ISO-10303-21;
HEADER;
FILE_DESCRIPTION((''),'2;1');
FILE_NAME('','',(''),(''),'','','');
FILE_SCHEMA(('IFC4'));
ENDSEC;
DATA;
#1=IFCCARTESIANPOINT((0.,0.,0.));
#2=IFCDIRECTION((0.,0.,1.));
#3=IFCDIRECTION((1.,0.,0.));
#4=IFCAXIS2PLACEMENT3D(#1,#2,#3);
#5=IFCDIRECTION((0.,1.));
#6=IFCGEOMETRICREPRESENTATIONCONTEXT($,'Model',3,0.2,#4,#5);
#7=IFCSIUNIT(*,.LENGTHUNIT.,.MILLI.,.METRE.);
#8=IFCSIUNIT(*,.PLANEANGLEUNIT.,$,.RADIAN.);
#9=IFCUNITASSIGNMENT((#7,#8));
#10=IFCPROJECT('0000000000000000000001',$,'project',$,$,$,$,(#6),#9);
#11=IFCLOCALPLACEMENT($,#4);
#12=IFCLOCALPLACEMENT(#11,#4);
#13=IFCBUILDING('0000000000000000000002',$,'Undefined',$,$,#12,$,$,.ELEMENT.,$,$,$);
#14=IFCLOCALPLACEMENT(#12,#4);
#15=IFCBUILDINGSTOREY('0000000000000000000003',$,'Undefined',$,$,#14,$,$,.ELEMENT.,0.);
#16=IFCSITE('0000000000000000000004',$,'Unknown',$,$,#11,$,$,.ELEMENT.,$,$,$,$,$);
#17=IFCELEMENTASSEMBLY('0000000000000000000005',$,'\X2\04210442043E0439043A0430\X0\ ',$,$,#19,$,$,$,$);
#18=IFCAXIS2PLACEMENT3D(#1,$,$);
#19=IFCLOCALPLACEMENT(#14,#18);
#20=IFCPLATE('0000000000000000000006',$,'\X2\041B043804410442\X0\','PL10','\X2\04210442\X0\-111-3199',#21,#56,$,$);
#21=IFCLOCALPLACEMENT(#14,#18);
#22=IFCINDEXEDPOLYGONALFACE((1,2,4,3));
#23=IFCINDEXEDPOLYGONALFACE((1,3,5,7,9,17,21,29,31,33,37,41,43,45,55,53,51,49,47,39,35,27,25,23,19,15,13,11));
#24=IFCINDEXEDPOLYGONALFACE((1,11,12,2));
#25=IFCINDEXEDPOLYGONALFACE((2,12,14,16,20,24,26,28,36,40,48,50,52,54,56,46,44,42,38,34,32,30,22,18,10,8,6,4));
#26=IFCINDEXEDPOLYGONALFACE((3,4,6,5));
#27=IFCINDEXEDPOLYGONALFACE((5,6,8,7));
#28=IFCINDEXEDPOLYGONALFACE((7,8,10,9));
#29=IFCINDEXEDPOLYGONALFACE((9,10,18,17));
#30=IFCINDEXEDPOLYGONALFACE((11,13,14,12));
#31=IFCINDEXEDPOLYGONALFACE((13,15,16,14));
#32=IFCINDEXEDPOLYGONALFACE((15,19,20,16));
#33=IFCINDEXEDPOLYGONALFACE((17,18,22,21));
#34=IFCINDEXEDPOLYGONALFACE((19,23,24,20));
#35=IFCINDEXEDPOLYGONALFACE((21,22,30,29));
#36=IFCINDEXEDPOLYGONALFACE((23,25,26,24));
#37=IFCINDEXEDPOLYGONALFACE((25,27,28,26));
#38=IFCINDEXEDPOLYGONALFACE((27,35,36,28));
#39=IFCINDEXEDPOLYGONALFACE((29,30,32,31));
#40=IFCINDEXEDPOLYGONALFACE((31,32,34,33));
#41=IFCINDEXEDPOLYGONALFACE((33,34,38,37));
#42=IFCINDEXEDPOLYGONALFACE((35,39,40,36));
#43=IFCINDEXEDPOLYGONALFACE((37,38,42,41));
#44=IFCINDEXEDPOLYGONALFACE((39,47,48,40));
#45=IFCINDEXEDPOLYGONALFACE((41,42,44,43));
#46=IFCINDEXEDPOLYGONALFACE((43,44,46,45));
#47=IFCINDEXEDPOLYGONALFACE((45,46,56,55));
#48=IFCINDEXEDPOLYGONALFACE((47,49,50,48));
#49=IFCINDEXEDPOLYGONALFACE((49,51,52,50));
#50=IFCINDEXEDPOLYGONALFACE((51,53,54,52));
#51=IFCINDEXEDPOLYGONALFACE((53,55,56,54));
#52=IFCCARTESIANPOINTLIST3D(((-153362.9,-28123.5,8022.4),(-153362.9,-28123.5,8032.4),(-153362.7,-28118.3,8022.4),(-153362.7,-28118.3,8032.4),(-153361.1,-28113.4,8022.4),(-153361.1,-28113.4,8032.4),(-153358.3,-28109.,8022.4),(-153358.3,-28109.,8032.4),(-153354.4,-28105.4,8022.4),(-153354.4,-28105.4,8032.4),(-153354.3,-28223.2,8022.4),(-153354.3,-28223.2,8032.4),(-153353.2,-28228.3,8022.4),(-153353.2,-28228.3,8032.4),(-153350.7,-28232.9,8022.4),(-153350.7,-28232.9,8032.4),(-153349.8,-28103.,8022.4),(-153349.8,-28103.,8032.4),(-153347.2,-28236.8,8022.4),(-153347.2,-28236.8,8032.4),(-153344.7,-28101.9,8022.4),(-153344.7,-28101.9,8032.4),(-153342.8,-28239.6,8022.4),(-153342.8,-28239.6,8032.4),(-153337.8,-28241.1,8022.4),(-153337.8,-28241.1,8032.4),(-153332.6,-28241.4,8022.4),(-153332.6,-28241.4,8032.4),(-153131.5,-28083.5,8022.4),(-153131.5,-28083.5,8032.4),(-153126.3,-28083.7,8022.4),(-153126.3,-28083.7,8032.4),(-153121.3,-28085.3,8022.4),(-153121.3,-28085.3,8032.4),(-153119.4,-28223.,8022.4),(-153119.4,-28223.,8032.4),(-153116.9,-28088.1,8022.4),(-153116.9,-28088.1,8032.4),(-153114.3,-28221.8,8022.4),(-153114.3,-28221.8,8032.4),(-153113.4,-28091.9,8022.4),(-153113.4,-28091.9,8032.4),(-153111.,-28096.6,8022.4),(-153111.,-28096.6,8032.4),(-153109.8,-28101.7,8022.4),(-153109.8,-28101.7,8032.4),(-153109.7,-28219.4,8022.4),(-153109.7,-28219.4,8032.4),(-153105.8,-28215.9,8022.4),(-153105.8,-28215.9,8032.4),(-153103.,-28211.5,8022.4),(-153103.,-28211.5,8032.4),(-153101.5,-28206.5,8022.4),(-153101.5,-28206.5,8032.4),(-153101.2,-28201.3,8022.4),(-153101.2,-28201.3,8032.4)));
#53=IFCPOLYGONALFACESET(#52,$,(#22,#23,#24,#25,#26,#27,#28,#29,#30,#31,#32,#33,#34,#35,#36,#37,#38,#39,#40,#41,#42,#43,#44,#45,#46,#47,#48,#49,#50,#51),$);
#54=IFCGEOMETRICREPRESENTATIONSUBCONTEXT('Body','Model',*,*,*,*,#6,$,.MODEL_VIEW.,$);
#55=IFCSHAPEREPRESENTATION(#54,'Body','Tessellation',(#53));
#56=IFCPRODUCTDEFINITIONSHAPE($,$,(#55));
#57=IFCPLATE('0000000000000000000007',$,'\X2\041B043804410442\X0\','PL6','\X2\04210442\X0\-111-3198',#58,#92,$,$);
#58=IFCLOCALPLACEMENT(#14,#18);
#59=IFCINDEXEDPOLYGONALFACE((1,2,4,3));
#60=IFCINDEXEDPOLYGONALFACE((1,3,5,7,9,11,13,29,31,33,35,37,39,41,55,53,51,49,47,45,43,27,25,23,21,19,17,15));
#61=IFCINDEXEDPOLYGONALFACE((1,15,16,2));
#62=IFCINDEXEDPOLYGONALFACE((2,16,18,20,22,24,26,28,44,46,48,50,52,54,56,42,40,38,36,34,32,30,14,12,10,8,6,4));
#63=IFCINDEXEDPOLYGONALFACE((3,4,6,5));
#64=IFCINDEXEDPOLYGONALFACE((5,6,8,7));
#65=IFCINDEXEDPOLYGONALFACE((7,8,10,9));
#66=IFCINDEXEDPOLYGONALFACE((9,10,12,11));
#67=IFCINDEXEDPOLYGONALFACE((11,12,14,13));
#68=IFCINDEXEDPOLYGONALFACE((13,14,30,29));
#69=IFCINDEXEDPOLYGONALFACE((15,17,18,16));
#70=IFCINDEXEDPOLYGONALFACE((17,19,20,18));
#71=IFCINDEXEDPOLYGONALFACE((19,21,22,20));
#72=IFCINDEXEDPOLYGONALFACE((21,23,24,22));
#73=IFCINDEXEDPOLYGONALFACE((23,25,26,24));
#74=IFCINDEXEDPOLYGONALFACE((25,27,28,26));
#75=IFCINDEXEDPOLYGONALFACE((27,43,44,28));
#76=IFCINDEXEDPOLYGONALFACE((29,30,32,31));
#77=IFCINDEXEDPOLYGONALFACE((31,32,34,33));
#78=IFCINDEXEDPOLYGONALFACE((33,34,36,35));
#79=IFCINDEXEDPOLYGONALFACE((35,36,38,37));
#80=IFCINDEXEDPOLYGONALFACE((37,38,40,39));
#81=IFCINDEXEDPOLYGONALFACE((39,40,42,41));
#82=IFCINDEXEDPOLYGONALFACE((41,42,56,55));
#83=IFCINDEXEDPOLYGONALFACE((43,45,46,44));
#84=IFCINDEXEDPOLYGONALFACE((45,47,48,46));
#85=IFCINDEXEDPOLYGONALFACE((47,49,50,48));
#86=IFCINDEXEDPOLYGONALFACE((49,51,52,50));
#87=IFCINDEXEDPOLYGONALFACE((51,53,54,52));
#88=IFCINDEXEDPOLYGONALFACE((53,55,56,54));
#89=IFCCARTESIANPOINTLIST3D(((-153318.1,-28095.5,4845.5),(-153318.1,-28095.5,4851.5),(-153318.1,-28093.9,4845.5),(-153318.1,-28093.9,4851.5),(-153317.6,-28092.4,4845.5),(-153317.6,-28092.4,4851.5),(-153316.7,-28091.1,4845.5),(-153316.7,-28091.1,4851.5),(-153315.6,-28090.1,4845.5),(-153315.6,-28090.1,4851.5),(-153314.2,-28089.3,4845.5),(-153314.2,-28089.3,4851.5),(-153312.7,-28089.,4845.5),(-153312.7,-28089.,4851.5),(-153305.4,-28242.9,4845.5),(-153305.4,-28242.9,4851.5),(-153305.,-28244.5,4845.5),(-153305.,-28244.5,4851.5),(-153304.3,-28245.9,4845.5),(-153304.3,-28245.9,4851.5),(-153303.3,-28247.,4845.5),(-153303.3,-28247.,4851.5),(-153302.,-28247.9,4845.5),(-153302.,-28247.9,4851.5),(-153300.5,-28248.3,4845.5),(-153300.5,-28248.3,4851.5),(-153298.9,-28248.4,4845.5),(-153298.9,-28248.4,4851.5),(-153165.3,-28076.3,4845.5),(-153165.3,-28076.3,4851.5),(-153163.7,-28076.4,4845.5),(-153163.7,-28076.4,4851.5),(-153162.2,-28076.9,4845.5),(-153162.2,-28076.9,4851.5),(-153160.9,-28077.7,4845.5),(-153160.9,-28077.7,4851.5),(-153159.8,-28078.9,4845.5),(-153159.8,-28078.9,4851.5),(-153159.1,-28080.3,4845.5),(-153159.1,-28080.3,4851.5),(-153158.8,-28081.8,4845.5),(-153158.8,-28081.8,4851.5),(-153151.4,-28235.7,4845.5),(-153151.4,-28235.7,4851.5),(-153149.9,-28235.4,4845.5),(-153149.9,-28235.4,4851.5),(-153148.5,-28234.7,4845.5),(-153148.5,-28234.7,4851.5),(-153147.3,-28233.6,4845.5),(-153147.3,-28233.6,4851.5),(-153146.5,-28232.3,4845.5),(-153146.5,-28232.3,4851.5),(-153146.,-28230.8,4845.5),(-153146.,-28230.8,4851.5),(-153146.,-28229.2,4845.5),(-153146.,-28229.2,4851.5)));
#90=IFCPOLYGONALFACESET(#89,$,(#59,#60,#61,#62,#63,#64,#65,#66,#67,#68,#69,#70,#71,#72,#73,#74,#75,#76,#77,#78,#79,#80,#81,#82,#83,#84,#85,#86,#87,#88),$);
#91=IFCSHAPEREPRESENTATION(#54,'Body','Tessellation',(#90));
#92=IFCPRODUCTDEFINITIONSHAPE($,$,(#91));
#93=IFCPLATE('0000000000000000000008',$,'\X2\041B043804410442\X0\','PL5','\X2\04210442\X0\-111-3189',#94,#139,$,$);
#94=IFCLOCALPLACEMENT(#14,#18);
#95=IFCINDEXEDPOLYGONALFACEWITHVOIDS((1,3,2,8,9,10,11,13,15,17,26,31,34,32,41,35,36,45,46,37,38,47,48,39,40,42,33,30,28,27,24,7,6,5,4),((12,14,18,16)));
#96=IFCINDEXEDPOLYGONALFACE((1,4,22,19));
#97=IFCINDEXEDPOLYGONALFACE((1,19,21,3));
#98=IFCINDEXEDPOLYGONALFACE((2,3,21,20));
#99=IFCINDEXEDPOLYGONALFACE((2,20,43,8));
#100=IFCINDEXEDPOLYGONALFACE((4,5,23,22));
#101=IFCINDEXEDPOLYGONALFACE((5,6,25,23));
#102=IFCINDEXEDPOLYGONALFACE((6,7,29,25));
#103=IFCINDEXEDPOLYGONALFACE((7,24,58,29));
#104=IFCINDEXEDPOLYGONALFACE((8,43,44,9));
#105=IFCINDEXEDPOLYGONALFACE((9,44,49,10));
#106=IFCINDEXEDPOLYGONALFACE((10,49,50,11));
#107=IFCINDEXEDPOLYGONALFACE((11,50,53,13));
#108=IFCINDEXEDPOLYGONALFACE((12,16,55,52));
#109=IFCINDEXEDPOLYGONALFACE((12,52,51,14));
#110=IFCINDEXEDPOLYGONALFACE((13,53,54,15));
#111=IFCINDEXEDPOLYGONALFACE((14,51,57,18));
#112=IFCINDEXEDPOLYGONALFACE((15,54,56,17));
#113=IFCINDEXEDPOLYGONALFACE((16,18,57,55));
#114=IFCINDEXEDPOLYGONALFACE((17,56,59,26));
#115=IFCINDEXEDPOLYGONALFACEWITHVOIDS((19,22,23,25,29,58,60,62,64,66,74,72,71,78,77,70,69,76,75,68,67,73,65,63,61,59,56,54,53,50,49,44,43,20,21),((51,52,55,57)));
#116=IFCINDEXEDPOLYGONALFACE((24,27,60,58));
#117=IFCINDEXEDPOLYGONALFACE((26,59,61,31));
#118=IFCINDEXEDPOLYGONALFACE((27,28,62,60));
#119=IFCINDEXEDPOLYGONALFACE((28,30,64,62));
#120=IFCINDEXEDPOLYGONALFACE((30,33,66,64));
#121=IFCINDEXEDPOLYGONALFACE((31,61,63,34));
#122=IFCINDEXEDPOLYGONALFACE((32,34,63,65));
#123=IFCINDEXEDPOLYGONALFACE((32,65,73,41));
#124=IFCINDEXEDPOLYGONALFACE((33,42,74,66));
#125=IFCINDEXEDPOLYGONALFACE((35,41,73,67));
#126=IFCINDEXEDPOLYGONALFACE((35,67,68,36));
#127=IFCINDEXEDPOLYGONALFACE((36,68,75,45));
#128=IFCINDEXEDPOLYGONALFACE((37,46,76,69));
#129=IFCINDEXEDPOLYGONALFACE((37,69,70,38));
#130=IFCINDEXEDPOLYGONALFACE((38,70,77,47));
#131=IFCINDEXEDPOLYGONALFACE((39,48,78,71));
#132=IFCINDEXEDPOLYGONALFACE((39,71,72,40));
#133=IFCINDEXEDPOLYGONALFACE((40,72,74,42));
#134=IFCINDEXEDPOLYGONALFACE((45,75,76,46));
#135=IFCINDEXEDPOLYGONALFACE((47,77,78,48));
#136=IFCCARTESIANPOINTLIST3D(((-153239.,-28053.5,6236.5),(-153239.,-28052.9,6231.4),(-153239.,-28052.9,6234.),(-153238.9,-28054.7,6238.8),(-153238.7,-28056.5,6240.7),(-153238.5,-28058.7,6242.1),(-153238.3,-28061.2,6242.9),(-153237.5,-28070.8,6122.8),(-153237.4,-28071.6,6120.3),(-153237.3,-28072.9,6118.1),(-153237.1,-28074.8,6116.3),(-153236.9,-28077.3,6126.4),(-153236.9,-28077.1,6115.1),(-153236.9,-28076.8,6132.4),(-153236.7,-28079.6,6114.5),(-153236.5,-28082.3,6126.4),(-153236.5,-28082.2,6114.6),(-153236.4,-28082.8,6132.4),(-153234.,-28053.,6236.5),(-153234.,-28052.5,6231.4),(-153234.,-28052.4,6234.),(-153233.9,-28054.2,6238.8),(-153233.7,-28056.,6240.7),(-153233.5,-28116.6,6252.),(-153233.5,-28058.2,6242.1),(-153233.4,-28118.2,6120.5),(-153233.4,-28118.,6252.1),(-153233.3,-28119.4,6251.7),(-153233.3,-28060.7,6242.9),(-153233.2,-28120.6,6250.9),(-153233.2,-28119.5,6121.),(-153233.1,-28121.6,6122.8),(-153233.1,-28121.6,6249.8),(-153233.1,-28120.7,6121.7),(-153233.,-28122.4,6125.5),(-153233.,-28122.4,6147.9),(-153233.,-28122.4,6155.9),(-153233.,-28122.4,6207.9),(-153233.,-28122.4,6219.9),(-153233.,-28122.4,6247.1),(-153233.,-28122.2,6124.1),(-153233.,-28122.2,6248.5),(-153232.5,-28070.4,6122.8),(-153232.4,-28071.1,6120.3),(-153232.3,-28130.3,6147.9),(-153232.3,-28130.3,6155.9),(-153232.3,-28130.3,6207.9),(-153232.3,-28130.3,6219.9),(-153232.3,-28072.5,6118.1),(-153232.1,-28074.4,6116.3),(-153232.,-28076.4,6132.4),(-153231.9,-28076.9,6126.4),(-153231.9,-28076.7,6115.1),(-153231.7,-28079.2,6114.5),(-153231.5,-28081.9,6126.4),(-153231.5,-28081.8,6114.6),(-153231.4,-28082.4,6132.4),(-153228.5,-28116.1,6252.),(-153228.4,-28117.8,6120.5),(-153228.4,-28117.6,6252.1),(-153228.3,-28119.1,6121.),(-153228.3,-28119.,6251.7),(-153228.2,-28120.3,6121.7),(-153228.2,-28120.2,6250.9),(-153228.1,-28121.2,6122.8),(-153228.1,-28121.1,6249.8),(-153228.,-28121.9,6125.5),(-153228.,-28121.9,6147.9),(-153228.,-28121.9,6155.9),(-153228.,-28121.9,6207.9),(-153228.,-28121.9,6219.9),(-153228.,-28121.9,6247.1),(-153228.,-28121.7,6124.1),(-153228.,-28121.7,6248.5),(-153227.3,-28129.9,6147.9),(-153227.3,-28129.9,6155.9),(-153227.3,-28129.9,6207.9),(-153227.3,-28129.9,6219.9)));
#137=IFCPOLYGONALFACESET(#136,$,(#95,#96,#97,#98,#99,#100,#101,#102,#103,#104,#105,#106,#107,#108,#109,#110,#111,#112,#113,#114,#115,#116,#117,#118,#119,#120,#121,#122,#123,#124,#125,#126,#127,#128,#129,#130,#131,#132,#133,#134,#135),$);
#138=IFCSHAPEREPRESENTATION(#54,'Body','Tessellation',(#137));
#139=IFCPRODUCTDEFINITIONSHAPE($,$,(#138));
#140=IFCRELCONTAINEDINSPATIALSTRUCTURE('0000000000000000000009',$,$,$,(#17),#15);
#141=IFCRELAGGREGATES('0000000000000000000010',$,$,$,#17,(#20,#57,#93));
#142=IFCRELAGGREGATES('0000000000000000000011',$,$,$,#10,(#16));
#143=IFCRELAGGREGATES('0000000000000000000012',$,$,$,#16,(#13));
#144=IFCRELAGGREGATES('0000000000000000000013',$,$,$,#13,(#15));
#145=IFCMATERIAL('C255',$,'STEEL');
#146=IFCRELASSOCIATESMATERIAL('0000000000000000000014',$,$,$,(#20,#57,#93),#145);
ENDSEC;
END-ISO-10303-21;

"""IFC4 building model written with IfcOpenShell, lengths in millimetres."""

from ifc_helpers import new_model, si_unit, direction, frame, origin_with_axes, place, context, subcontext, project, spatial, line, arc, indexed_curve, outline, extrude, material, element, aggregate, save


model = new_model("IFC4")

# Units and contexts
model_context = context("Model", 3, precision=0.2, world=origin_with_axes(), true_north=direction((0.0, 1.0)))
body_context = subcontext(model_context, "Body", "Model", "MODEL_VIEW")
ifc_project = project(units=[si_unit("LENGTHUNIT", "METRE", prefix="MILLI"), si_unit("PLANEANGLEUNIT", "RADIAN")], contexts=[model_context])

# Site, building, storey
site_placement = place(None, origin_with_axes())
site = spatial("IfcSite", under=ifc_project, at=site_placement, Name="Unknown", CompositionType="ELEMENT")
building_placement = place(site_placement, origin_with_axes())
building = spatial("IfcBuilding", under=site, at=building_placement, Name="Undefined", CompositionType="ELEMENT")
storey_placement = place(building_placement, origin_with_axes())
storey = spatial("IfcBuildingStorey", under=building, at=storey_placement, Name="Undefined", CompositionType="ELEMENT", Elevation=0.0)

# Element assembly, plates, voiding feature
assembly_1_placement = place(storey_placement, frame((-153232.0, -28162.4, 4934.6), z_axis=(-0.086114, 0.996285, 0.0), x_axis=(0.0, 0.0, 1.0)))
assembly_1 = element("IfcElementAssembly", 1, at=assembly_1_placement, inside=storey, Name="Стойка ")
ifc_material_1 = material(Name="C255", Category="STEEL")
plate_1_placement = place(assembly_1_placement, frame((3092.9, 127.0, 70.0), z_axis=(1.0, 0.0, 0.0), x_axis=(0.0, -1.0, 0.0)))
plate_1 = element("IfcPlate", 2, at=plate_1_placement, material=ifc_material_1, Name="Лист", Description="PL10", ObjectType="Ст-111-3199", context=body_context, shape_type="SolidModel", body=[
    extrude(outline(indexed_curve([(0.0, 20.0), (5.9, 5.9), (20.0, 0.0), (234.0, 0.0), (248.1, 5.9), (254.0, 20.0), (254.0, 120.0), (248.1, 134.1), (234.0, 140.0), (20.0, 140.0), (5.9, 134.1), (0.0, 120.0)], segments=[arc(1, 2, 3), line(3, 4), arc(4, 5, 6), line(6, 7), arc(7, 8, 9), line(9, 10), arc(10, 11, 12), line(12, 1)])), frame((0.0, 0.0, 5.0), z_axis=(0.0, 0.0, 1.0), x_axis=(1.0, 0.0, 0.0)), (0.0, 0.0, -1.0), 10.0),
])
plate_2_placement = place(assembly_1_placement, frame((-86.1, 80.0, -80.0), z_axis=(1.0, -0.000024, 0.0), x_axis=(0.0, -0.000366, 1.0)))
plate_2 = element("IfcPlate", 3, at=plate_2_placement, material=ifc_material_1, Name="Лист", Description="PL6", ObjectType="Ст-111-3198", context=body_context, shape_type="SolidModel", body=[
    extrude(outline(indexed_curve([(0.0, 6.0), (1.8, 1.8), (6.0, 0.0), (154.0, 0.0), (158.2, 1.8), (160.0, 6.0), (160.1, 154.0), (158.4, 158.2), (154.1, 160.0), (6.1, 160.0), (1.9, 158.3), (0.1, 154.0)], segments=[arc(1, 2, 3), line(3, 4), arc(4, 5, 6), line(6, 7), arc(7, 8, 9), line(9, 10), arc(10, 11, 12), line(12, 1)])), frame((0.0, 0.0, 3.0), z_axis=(0.0, 0.0, 1.0), x_axis=(1.0, 0.0, 0.0)), (0.0, 0.0, -1.0), 6.0),
])
plate_3_placement = place(assembly_1_placement, frame((1178.4, 5.0, 90.1), z_axis=(-0.000024, 1.0, 0.0), x_axis=(0.986646, 0.000024, 0.162881)))
plate_3 = element("IfcPlate", 4, at=plate_3_placement, material=ifc_material_1, Name="Лист", Description="PL5", ObjectType="Ст-111-3189", context=body_context, shape_type="SolidModel", body=[
    extrude(outline(indexed_curve([(0.0, 10.0), (2.9, 2.9), (10.0, 0.0), (120.0, 0.0), (127.1, 2.9), (130.0, 10.0), (130.0, 66.4), (128.2, 70.2), (124.2, 71.3), (97.4, 66.9), (96.1, 74.8), (84.2, 72.8), (85.5, 64.9), (34.2, 56.5), (32.9, 64.4), (25.0, 63.1), (26.4, 55.2), (4.2, 51.5), (1.2, 49.8), (0.0, 46.6)], segments=[arc(1, 2, 3), line(3, 4), arc(4, 5, 6), line(6, 7), arc(7, 8, 9), line(9, 10, 11, 12, 13, 14, 15, 16, 17, 18), arc(18, 19, 20), line(20, 1)])), frame((0.0, 0.0, 2.5), z_axis=(0.0, 0.0, 1.0), x_axis=(1.0, 0.0, 0.0)), (0.0, 0.0, -1.0), 5.0),
])
voiding_feature_1_placement = place(plate_3_placement, frame((15.0, 10.0, 10.0), z_axis=(0.165862, -0.986149, 0.0), x_axis=(0.0, 0.0, -1.0)))
element("IfcVoidingFeature", 5, at=voiding_feature_1_placement, cuts=plate_3, Name="Балка", ObjectType="(?)", PredefinedType="HOLE", context=body_context, shape_type="SolidModel", body=[
    extrude(outline(indexed_curve([(2.5, -3.0), (3.0, 3.0), (-3.0, 3.0), (-2.5, -3.0)], segments=[line(1, 2, 3, 4, 1)])), frame((0.0, 0.0, 0.0), z_axis=(-1.0, 0.0, 0.0), x_axis=(0.0, 0.0, 1.0)), (0.0, 0.0, -1.0), 20.0),
])

aggregate(assembly_1, [plate_1, plate_2, plate_3])

save(model, "model.ifc")
